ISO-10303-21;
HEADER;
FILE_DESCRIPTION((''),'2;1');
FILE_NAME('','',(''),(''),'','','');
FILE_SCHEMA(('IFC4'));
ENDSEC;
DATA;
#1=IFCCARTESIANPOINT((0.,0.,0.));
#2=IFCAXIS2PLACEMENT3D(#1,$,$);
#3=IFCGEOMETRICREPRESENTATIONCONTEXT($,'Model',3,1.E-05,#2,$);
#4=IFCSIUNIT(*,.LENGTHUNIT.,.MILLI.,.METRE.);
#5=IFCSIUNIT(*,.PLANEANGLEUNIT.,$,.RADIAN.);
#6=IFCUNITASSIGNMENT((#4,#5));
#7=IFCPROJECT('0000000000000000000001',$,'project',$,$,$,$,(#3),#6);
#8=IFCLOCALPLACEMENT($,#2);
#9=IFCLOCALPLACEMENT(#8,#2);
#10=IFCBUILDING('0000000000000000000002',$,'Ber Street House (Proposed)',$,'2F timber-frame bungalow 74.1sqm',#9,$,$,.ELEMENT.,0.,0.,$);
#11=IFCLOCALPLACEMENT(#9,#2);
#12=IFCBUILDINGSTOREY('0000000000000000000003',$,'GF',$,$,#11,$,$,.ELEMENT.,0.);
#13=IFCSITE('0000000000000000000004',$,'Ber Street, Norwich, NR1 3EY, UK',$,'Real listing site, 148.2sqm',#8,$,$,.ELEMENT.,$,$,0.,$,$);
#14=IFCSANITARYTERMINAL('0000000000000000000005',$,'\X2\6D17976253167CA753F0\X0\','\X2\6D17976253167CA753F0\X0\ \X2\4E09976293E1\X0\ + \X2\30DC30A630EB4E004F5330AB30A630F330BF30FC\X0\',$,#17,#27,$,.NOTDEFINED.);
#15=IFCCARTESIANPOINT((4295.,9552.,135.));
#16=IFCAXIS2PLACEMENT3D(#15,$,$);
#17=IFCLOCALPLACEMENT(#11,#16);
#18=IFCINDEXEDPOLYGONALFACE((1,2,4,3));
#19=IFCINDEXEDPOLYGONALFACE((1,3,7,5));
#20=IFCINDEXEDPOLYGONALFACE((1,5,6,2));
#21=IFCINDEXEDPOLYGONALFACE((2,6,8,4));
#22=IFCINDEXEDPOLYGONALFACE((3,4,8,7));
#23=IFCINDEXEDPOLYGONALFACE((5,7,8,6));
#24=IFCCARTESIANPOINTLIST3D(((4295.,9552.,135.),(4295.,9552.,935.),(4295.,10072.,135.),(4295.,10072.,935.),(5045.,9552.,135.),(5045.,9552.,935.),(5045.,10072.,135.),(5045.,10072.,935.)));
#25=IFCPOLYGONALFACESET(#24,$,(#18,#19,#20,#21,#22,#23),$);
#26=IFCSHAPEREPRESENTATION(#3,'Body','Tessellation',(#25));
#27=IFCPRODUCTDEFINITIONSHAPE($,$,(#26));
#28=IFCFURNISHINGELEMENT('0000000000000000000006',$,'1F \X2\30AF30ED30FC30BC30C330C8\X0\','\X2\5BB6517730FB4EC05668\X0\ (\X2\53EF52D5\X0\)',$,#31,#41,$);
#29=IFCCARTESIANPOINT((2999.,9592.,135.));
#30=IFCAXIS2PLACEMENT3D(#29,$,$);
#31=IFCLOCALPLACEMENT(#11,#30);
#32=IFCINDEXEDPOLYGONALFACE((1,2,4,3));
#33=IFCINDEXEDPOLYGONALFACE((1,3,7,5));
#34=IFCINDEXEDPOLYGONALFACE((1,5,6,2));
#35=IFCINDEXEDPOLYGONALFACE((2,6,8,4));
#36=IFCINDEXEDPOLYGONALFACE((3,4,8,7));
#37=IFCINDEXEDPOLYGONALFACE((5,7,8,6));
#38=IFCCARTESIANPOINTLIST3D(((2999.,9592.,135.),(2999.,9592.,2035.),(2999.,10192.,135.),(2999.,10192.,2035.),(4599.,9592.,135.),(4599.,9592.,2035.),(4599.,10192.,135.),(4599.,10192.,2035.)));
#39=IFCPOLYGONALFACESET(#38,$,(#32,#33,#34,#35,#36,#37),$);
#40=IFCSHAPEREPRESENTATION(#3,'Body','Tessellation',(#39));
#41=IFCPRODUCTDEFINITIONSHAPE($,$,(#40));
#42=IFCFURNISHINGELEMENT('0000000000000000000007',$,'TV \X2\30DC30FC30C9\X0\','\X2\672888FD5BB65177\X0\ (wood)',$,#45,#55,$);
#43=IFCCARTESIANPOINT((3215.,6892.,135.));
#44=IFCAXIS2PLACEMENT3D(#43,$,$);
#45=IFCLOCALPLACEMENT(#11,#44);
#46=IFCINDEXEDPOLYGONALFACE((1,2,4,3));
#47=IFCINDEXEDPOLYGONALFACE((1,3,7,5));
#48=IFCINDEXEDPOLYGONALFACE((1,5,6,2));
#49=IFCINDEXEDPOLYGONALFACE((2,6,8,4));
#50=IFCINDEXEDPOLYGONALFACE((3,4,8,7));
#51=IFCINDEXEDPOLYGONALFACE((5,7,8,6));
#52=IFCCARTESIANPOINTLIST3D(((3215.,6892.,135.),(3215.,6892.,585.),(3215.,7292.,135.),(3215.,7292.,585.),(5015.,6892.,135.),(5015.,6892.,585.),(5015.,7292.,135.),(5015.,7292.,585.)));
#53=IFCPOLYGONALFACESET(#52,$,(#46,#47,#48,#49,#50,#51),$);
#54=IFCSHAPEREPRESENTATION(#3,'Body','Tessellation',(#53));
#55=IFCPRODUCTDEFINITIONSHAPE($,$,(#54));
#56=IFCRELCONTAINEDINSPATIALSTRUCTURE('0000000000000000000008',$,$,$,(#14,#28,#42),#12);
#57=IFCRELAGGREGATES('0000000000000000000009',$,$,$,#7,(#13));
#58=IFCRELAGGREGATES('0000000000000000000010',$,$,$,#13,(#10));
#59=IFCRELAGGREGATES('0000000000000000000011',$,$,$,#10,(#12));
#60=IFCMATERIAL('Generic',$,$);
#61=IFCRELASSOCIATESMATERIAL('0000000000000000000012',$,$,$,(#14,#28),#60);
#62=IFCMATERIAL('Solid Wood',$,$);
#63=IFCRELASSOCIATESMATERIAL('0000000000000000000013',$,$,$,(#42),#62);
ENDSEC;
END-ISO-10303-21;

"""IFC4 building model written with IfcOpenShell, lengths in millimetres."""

from ifc_helpers import new_model, si_unit, frame, frame_2d, origin, place, context, project, spatial, rectangle, extrude, material, element, save


model = new_model("IFC4")

# Units and contexts
model_context = context("Model", 3, precision=1e-05, world=origin())
ifc_project = project(units=[si_unit("LENGTHUNIT", "METRE", prefix="MILLI"), si_unit("PLANEANGLEUNIT", "RADIAN")], contexts=[model_context])

# Site, building, storey
site_placement = place(None, origin())
site = spatial("IfcSite", under=ifc_project, at=site_placement, Name="Ber Street, Norwich, NR1 3EY, UK", ObjectType="Real listing site, 148.2sqm", CompositionType="ELEMENT", RefElevation=0.0)
building_placement = place(site_placement, origin())
building = spatial("IfcBuilding", under=site, at=building_placement, Name="Ber Street House (Proposed)", ObjectType="2F timber-frame bungalow 74.1sqm", CompositionType="ELEMENT", ElevationOfRefHeight=0.0, ElevationOfTerrain=0.0)
storey_placement = place(building_placement, origin())
storey = spatial("IfcBuildingStorey", under=building, at=storey_placement, Name="GF", CompositionType="ELEMENT", Elevation=0.0)

# Shared definitions
ifc_material_1 = material(Name="Solid Wood")

# Shared definitions
ifc_material_2 = material(Name="Generic")

# Sanitary terminal
sanitary_terminal_1_placement = place(storey_placement, frame((4295.0, 9552.0, 135.0)))
element("IfcSanitaryTerminal", 1, at=sanitary_terminal_1_placement, inside=storey, material=ifc_material_2, Name="洗面化粧台", Description="洗面化粧台 三面鏡 + ボウル一体カウンター", PredefinedType="NOTDEFINED", context=model_context, shape_type="SweptSolid", body=[
    extrude(rectangle(XDim=750.0, YDim=520.0, at=frame_2d((375.0, 260.0))), frame((4295.0, 9552.0, 135.0)), (0.0, 0.0, 1.0), 800.0),
])

# Furnishing elements
furnishing_1_placement = place(storey_placement, frame((2999.0, 9592.0, 135.0)))
element("IfcFurnishingElement", 2, at=furnishing_1_placement, inside=storey, material=ifc_material_2, Name="1F クローゼット", Description="家具・什器 (可動)", context=model_context, shape_type="SweptSolid", body=[
    extrude(rectangle(XDim=1600.0, YDim=600.0, at=frame_2d((800.0, 300.0))), frame((2999.0, 9592.0, 135.0)), (0.0, 0.0, 1.0), 1900.0),
])
furnishing_2_placement = place(storey_placement, frame((3215.0, 6892.0, 135.0)))
element("IfcFurnishingElement", 3, at=furnishing_2_placement, inside=storey, material=ifc_material_1, Name="TV ボード", Description="木製家具 (wood)", context=model_context, shape_type="SweptSolid", body=[
    extrude(rectangle(XDim=1800.0, YDim=400.0, at=frame_2d((900.0, 200.0))), frame((3215.0, 6892.0, 135.0)), (0.0, 0.0, 1.0), 450.0),
])

save(model, "model.ifc")
